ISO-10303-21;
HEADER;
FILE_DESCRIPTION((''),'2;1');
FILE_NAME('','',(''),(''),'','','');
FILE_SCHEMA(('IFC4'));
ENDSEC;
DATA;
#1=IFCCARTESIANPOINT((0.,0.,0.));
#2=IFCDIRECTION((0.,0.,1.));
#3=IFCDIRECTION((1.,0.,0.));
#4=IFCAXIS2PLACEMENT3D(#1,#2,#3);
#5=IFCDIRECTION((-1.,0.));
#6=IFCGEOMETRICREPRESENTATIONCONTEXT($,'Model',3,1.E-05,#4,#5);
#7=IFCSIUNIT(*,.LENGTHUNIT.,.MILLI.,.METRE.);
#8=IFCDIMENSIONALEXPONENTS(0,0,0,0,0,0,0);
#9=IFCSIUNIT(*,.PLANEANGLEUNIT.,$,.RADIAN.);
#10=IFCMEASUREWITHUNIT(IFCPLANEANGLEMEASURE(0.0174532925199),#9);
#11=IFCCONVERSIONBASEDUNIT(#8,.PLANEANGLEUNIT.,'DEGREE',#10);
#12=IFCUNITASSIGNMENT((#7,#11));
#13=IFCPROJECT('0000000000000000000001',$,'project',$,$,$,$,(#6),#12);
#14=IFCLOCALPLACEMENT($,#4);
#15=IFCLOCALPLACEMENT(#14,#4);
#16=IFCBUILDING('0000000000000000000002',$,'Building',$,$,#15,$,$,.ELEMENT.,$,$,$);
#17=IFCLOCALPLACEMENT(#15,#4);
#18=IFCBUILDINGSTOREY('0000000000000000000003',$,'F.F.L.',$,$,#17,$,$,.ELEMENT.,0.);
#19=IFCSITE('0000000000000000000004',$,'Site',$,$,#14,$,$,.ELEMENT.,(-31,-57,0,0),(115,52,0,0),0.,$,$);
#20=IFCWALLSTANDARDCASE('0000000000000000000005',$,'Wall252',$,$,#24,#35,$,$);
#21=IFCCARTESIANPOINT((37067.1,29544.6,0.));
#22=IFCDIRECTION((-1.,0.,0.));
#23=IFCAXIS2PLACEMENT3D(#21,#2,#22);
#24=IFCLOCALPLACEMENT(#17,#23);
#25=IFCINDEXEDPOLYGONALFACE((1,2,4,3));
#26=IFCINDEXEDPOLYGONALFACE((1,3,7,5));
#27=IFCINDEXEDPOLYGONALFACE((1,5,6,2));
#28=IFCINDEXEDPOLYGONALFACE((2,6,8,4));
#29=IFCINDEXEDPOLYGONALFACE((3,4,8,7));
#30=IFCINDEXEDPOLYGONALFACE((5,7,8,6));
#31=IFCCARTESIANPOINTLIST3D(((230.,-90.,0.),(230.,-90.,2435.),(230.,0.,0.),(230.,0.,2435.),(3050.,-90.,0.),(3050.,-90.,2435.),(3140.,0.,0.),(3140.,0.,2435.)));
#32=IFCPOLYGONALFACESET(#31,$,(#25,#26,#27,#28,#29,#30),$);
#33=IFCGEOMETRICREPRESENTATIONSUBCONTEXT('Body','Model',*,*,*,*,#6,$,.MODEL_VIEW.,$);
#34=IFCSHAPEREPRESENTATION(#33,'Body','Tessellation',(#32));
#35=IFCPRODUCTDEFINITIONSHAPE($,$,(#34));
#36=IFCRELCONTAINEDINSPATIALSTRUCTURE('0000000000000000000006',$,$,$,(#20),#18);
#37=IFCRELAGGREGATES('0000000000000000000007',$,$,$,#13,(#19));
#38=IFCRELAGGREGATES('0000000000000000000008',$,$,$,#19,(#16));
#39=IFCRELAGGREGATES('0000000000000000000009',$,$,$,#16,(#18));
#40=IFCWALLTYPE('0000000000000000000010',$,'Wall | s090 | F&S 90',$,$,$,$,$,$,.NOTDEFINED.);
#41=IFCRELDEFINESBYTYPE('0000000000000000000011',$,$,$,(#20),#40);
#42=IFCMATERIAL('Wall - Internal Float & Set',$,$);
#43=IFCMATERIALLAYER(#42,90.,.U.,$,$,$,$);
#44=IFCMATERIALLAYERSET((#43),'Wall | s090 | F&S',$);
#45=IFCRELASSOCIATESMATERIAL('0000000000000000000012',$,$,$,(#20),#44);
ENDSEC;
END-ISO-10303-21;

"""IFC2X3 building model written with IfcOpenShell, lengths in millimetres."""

from ifc_helpers import new_model, entity, si_unit, converted_unit, direction, frame, origin_with_axes, place, context, subcontext, project, spatial, polyline, outline, extrude, material, layer, layer_set, layer_usage, type_object, element, save


model = new_model("IFC2X3")

# Units and contexts
model_context = context("Model", 3, precision=1e-05, world=origin_with_axes(), true_north=direction((-1.0, 0.0)))
body_context = subcontext(model_context, "Body", "Model", "MODEL_VIEW")
ifc_project = project(units=[si_unit("LENGTHUNIT", "METRE", prefix="MILLI"), converted_unit("PLANEANGLEUNIT", "DEGREE", entity("IfcPlaneAngleMeasure", 0.0174532925199), si_unit("PLANEANGLEUNIT", "RADIAN"), dimensions=[0, 0, 0, 0, 0, 0, 0])], contexts=[model_context])

# Site, building, storey
site_placement = place(None, origin_with_axes())
site = spatial("IfcSite", under=ifc_project, at=site_placement, Name="Site", CompositionType="ELEMENT", RefLatitude=(-31, -57, 0, 0), RefLongitude=(115, 52, 0, 0), RefElevation=0.0)
building_placement = place(site_placement, origin_with_axes())
building = spatial("IfcBuilding", under=site, at=building_placement, Name="Building", CompositionType="ELEMENT")
storey_placement = place(building_placement, origin_with_axes())
storey = spatial("IfcBuildingStorey", under=building, at=storey_placement, Name="F.F.L.", CompositionType="ELEMENT", Elevation=0.0)

# Shared definitions
ifc_material_1 = material(Name="Wall - Internal Float & Set")
ifc_layer = layer(ifc_material_1, 90.0, ventilated="UNKNOWN")
ifc_layer_set = layer_set([ifc_layer], Name="Wall | s090 | F&S")
wall_type = type_object("IfcWallType", Name="Wall | s090 | F&S 90", PredefinedType="NOTDEFINED")

# Wall
ifc_layer_usage_1 = layer_usage(ifc_layer_set, "AXIS2", "POSITIVE", -90.0)
wall_1_placement = place(storey_placement, frame((37067.1, 29544.6, 0.0), z_axis=(0.0, 0.0, 1.0), x_axis=(-1.0, 0.0, 0.0)))
element("IfcWallStandardCase", 1, at=wall_1_placement, inside=storey, type_object=wall_type, material=ifc_layer_usage_1, Name="Wall252", context=body_context, shape_type="SweptSolid", body=[
    extrude(outline(polyline([(230.0, -90.0), (3050.0, -90.0), (3140.0, 0.0), (230.0, 0.0), (230.0, -90.0)])), origin_with_axes(), (0.0, 0.0, 1.0), 2435.0),
])

save(model, "model.ifc")
